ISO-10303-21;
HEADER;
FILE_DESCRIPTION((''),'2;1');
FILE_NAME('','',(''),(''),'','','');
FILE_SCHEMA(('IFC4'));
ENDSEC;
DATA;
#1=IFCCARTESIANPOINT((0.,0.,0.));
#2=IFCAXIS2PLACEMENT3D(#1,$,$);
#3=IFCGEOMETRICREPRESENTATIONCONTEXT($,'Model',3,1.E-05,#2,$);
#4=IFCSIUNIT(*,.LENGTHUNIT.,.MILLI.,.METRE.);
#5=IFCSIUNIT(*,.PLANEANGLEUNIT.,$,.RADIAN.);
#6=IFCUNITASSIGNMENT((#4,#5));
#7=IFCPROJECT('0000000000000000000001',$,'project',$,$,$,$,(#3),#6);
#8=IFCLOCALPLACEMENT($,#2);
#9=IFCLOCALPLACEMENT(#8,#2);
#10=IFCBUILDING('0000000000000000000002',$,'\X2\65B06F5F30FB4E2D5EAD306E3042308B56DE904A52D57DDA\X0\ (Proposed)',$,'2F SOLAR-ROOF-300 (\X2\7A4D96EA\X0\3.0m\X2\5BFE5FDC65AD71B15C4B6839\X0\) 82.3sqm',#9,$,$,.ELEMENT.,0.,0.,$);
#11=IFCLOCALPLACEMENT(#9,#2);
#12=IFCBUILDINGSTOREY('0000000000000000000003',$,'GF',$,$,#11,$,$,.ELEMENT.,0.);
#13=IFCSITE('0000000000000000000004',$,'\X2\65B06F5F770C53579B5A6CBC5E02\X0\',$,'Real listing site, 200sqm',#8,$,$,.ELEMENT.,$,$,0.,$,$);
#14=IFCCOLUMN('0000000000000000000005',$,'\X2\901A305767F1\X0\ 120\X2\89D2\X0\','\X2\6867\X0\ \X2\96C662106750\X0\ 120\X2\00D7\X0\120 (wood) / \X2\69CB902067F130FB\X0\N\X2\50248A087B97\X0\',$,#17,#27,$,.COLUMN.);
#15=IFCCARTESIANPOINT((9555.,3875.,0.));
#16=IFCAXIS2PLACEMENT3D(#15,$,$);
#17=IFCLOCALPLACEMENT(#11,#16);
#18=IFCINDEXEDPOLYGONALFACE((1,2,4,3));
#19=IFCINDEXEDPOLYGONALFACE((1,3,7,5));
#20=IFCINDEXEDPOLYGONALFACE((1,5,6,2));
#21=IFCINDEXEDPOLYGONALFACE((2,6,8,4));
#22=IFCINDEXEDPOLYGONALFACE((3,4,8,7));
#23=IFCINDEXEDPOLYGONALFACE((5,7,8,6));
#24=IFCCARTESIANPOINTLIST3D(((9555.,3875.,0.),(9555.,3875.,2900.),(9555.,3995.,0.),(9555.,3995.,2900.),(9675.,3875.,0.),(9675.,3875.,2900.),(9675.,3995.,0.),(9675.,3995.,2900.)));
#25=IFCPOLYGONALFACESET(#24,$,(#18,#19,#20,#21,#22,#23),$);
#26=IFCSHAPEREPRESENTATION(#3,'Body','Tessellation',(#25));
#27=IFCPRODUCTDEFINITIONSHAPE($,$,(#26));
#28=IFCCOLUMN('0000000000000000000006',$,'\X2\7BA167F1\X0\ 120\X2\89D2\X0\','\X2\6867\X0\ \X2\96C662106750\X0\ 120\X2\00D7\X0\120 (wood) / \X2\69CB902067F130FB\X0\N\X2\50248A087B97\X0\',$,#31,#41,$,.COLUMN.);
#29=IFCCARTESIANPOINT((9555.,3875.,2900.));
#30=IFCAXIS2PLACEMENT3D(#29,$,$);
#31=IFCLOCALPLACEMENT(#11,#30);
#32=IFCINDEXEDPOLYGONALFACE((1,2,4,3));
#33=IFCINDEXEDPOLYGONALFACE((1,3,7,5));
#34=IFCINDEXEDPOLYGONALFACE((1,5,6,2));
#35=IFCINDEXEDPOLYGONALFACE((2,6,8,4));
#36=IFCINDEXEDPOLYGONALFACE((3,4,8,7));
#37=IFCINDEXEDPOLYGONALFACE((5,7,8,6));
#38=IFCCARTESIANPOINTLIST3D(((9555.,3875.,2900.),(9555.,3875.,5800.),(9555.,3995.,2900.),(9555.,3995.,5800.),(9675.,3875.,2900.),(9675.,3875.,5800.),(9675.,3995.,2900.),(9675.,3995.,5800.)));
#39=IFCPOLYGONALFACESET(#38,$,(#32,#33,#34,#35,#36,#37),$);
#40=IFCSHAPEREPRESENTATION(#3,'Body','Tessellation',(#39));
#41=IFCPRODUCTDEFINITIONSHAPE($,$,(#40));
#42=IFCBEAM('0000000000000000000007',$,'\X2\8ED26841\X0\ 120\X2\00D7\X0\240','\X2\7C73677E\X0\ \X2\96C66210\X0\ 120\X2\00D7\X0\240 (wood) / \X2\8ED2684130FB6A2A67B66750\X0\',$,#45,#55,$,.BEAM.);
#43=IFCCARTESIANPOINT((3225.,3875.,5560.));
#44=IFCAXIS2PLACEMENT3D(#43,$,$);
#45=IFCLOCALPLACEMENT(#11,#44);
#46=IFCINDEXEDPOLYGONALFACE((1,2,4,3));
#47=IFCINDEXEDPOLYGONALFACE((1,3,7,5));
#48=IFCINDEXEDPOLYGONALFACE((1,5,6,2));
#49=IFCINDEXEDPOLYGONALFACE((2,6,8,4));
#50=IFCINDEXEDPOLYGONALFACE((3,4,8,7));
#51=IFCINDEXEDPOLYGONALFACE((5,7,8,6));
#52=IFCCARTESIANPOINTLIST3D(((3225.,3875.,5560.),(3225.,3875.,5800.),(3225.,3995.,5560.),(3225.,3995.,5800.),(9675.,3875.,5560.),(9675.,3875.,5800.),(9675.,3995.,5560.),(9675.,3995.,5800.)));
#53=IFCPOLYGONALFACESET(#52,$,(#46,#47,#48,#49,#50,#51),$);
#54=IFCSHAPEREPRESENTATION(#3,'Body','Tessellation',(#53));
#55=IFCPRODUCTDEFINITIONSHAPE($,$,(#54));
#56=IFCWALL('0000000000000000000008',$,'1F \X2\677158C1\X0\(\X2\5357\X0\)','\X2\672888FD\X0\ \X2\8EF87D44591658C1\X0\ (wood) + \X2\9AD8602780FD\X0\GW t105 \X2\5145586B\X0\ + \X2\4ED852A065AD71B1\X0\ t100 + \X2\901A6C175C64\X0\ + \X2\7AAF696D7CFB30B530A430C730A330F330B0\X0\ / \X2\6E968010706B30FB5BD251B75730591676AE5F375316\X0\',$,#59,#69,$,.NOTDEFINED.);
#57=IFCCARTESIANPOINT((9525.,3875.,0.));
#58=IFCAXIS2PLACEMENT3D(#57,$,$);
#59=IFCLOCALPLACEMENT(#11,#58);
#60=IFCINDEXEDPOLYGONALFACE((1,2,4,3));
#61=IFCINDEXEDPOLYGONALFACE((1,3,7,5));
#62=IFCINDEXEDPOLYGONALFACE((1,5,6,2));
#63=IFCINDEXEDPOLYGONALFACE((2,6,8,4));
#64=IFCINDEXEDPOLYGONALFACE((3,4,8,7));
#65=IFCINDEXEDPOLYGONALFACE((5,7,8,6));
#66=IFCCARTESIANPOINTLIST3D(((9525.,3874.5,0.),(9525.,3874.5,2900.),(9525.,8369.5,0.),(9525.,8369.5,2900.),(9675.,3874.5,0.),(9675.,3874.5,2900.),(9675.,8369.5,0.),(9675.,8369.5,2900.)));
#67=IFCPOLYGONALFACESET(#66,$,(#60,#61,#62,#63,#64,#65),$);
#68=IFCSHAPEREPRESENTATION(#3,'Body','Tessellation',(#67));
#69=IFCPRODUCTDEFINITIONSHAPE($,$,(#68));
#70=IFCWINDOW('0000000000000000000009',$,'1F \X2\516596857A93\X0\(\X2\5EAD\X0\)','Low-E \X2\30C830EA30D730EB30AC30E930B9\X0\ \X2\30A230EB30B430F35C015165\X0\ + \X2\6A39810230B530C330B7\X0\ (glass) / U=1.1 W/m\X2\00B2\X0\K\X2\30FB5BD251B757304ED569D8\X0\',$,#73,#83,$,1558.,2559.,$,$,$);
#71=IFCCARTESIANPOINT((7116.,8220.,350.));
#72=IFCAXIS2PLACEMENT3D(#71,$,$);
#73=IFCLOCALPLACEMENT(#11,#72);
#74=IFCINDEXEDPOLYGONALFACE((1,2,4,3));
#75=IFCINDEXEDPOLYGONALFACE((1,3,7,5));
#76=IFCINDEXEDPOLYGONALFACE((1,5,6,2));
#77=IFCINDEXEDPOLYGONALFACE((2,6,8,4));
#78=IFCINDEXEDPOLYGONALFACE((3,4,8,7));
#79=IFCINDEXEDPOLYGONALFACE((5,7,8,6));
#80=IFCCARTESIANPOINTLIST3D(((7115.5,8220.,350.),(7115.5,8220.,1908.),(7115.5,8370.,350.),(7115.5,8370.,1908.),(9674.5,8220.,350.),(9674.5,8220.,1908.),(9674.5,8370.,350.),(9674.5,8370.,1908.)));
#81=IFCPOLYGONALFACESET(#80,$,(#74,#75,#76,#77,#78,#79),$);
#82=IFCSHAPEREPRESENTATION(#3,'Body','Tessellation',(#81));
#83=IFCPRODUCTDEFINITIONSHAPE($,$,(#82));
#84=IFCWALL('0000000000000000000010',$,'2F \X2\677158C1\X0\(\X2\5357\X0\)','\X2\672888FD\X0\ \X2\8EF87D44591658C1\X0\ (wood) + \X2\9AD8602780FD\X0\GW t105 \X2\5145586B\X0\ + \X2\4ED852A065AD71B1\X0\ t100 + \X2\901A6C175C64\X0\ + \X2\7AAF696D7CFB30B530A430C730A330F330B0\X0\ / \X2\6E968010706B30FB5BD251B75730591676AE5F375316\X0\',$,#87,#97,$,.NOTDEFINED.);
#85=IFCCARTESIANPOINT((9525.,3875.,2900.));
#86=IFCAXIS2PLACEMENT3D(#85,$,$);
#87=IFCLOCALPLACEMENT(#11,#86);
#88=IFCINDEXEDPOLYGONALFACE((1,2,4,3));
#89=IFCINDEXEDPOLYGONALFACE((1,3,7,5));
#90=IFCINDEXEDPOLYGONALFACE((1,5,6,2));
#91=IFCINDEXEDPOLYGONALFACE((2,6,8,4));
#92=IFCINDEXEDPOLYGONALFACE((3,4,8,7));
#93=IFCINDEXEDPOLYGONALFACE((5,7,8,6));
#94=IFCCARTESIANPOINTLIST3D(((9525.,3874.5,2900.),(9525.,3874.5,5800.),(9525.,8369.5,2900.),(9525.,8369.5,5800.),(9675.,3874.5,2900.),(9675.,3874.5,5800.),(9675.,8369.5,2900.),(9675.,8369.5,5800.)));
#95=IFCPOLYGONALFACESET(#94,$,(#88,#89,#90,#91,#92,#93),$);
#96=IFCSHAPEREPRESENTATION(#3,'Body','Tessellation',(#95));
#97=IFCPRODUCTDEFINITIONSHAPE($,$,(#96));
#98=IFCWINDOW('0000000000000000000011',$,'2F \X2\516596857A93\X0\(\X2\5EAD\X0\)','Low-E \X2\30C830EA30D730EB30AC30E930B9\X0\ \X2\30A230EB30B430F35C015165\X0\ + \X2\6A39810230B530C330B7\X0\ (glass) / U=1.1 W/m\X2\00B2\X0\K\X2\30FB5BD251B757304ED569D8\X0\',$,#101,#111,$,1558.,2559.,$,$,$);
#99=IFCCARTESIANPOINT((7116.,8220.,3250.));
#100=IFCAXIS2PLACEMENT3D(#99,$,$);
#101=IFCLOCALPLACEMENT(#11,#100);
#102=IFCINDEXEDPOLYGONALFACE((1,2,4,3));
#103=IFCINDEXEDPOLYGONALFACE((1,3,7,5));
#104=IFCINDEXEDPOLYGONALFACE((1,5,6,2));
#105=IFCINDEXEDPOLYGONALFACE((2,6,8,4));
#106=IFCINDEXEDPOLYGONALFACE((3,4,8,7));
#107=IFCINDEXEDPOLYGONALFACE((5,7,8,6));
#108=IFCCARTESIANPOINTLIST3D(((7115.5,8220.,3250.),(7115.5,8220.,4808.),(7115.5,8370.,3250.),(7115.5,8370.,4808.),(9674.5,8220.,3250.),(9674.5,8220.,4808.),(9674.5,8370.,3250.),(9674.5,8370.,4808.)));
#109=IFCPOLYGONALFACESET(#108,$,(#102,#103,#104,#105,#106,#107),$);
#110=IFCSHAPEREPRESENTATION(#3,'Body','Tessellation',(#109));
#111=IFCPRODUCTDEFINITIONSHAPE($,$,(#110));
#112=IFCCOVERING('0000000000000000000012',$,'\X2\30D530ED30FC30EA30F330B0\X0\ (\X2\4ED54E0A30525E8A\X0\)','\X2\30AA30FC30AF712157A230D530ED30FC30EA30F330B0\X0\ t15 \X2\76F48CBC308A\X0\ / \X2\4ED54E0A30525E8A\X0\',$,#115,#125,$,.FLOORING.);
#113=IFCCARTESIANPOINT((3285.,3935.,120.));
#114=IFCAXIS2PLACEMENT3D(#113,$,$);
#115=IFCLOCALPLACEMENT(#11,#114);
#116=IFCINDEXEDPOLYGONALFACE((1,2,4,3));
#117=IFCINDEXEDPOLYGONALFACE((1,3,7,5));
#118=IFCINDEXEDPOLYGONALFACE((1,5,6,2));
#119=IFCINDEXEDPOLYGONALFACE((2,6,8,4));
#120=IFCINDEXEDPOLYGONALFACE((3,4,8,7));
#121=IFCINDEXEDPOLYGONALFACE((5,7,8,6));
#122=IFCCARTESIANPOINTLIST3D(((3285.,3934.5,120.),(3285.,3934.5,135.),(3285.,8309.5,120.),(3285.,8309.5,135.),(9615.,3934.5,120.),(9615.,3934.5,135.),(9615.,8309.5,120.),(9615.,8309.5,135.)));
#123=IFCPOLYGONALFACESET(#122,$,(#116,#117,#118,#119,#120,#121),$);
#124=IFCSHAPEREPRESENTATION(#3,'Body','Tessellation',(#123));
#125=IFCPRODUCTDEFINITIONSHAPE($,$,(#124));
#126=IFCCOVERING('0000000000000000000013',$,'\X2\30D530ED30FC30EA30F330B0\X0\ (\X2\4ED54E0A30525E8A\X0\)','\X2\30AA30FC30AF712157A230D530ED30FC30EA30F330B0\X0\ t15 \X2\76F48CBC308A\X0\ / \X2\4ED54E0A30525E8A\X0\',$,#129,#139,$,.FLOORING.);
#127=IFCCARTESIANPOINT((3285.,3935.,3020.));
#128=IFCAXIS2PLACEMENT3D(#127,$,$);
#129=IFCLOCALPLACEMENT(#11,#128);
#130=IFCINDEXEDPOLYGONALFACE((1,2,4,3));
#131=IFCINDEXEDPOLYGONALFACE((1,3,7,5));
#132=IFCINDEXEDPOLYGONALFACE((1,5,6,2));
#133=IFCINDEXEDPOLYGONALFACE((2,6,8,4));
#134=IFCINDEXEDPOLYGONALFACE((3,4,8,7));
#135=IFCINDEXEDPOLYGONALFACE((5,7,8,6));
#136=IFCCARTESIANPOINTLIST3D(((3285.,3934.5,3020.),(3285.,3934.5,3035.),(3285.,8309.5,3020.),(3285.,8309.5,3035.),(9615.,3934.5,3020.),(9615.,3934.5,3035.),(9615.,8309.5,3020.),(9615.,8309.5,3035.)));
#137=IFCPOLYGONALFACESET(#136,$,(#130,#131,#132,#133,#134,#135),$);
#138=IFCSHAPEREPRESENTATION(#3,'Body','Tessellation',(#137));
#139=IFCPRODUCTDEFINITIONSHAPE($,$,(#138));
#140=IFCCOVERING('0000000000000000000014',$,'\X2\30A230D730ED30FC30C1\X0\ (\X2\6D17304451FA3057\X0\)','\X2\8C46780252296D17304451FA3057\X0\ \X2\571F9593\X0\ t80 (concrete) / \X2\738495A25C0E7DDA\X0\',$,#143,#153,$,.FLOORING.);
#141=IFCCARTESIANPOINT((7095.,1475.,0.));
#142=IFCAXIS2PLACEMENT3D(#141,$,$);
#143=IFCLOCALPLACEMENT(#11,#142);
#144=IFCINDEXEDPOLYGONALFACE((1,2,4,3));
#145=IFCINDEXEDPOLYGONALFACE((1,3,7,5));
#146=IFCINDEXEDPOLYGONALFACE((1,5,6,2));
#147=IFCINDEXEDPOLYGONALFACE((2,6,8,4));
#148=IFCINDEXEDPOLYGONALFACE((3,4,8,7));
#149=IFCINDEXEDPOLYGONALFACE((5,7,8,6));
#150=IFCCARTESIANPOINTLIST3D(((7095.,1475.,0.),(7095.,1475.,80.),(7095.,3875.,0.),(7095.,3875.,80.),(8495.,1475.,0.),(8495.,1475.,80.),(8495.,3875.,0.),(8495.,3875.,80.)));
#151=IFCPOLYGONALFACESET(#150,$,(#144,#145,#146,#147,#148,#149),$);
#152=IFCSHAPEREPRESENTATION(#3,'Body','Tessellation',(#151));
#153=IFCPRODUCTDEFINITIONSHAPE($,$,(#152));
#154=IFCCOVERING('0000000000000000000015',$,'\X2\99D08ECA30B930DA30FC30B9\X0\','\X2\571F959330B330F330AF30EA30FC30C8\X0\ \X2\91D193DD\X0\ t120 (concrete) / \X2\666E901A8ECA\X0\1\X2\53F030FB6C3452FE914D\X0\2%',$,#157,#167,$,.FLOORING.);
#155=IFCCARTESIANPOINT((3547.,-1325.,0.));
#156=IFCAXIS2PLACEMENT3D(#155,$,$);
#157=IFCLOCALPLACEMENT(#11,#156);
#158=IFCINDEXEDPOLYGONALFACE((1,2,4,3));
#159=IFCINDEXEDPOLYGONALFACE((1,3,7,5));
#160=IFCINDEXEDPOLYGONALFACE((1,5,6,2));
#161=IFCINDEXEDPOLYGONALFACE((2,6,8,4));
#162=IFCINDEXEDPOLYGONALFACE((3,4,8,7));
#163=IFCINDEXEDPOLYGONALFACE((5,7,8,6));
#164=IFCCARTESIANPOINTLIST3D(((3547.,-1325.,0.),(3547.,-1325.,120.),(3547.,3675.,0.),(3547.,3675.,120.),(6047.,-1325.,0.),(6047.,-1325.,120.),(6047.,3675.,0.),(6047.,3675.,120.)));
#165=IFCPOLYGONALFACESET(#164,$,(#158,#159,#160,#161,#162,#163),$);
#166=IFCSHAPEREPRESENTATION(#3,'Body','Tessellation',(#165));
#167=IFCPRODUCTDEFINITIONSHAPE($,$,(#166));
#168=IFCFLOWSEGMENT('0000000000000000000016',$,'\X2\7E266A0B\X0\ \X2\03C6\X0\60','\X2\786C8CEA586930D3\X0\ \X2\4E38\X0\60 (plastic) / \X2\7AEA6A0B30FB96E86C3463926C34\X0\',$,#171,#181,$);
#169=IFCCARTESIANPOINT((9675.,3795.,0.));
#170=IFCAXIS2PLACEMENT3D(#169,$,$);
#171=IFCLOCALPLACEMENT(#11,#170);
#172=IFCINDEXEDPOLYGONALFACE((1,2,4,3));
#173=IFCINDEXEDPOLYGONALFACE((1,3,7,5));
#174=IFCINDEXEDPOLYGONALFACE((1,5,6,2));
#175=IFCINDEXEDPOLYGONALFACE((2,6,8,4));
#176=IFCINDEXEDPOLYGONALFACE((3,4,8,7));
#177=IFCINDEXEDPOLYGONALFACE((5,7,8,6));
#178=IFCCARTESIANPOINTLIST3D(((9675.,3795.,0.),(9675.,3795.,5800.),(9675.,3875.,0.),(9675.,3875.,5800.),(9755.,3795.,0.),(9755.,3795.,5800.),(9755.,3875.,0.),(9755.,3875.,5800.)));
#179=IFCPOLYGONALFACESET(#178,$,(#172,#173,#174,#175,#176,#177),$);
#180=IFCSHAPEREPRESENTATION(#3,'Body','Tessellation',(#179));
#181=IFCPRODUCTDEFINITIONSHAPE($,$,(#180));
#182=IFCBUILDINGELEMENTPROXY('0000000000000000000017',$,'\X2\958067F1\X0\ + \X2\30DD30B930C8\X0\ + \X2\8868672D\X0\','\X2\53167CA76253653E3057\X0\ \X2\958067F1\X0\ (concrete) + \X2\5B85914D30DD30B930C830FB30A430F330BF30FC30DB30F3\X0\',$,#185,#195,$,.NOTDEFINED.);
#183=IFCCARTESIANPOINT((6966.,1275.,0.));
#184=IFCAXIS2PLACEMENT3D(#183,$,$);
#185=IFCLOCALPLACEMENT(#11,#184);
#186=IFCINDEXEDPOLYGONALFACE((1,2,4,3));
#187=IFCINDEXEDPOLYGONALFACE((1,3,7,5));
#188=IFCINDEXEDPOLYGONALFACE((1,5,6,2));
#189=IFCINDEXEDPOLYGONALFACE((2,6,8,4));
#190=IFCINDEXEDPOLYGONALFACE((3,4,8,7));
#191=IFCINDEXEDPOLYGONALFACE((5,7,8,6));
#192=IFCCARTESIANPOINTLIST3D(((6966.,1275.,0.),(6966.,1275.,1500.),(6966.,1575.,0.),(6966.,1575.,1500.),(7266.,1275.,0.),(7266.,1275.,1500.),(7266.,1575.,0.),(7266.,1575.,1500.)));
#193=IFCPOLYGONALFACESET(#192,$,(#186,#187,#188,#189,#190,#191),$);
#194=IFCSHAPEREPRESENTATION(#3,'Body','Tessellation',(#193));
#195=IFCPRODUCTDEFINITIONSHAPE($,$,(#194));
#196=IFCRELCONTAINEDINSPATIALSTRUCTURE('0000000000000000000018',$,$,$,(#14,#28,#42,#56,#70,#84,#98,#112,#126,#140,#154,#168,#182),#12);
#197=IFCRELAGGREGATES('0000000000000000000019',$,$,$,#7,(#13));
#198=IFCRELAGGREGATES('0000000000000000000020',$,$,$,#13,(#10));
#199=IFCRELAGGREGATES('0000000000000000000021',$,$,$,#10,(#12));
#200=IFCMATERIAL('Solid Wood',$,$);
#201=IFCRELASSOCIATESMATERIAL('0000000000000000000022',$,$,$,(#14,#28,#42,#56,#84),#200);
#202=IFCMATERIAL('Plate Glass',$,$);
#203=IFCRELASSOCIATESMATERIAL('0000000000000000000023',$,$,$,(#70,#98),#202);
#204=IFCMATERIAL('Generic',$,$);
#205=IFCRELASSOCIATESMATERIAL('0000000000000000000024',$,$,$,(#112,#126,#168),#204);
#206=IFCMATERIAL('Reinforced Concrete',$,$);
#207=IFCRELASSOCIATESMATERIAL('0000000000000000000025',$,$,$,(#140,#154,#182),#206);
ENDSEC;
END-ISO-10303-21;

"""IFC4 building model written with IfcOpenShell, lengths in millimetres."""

from ifc_helpers import new_model, si_unit, frame, frame_2d, origin, place, context, project, spatial, rectangle, extrude, material, element, fill, save


model = new_model("IFC4")

# Units and contexts
model_context = context("Model", 3, precision=1e-05, world=origin())
ifc_project = project(units=[si_unit("LENGTHUNIT", "METRE", prefix="MILLI"), si_unit("PLANEANGLEUNIT", "RADIAN")], contexts=[model_context])

# Site, building, storey
site_placement = place(None, origin())
site = spatial("IfcSite", under=ifc_project, at=site_placement, Name="新潟県南魚沼市", ObjectType="Real listing site, 200sqm", CompositionType="ELEMENT", RefElevation=0.0)
building_placement = place(site_placement, origin())
building = spatial("IfcBuilding", under=site, at=building_placement, Name="新潟・中庭のある回遊動線 (Proposed)", ObjectType="2F SOLAR-ROOF-300 (積雪3.0m対応断熱屋根) 82.3sqm", CompositionType="ELEMENT", ElevationOfRefHeight=0.0, ElevationOfTerrain=0.0)
storey_placement = place(building_placement, origin())
storey = spatial("IfcBuildingStorey", under=building, at=storey_placement, Name="GF", CompositionType="ELEMENT", Elevation=0.0)

# Columns
ifc_material_1 = material(Name="Solid Wood")
column_1_placement = place(storey_placement, frame((9555.0, 3875.0, 0.0)))
element("IfcColumn", 1, at=column_1_placement, inside=storey, material=ifc_material_1, Name="通し柱 120角", Description="桧 集成材 120×120 (wood) / 構造柱・N値計算", PredefinedType="COLUMN", context=model_context, shape_type="SweptSolid", body=[
    extrude(rectangle(XDim=120.0, YDim=120.0, at=frame_2d((60.0, 60.0))), frame((9555.0, 3875.0, 0.0)), (0.0, 0.0, 1.0), 2900.0),
])
column_2_placement = place(storey_placement, frame((9555.0, 3875.0, 2900.0)))
element("IfcColumn", 2, at=column_2_placement, inside=storey, material=ifc_material_1, Name="管柱 120角", Description="桧 集成材 120×120 (wood) / 構造柱・N値計算", PredefinedType="COLUMN", context=model_context, shape_type="SweptSolid", body=[
    extrude(rectangle(XDim=120.0, YDim=120.0, at=frame_2d((60.0, 60.0))), frame((9555.0, 3875.0, 2900.0)), (0.0, 0.0, 1.0), 2900.0),
])

# Beam
beam_1_placement = place(storey_placement, frame((3225.0, 3875.0, 5560.0)))
element("IfcBeam", 3, at=beam_1_placement, inside=storey, material=ifc_material_1, Name="軒桁 120×240", Description="米松 集成 120×240 (wood) / 軒桁・横架材", PredefinedType="BEAM", context=model_context, shape_type="SweptSolid", body=[
    extrude(rectangle(XDim=6450.0, YDim=120.0, at=frame_2d((3225.0, 60.0))), frame((3225.0, 3875.0, 5560.0)), (0.0, 0.0, 1.0), 240.0),
])

# Wall, opening, window
wall_1_placement = place(storey_placement, frame((9525.0, 3875.0, 0.0)))
wall_1 = element("IfcWall", 4, at=wall_1_placement, inside=storey, material=ifc_material_1, Name="1F 東壁(南)", Description="木製 軸組外壁 (wood) + 高性能GW t105 充填 + 付加断熱 t100 + 通気層 + 窯業系サイディング / 準耐火・寒冷地外皮強化", PredefinedType="NOTDEFINED", context=model_context, shape_type="SweptSolid", body=[
    extrude(rectangle(XDim=150.0, YDim=4495.0, at=frame_2d((75.0, 2247.0))), frame((9525.0, 3875.0, 0.0)), (0.0, 0.0, 1.0), 2900.0),
])
opening_1_placement = place(storey_placement, frame((7116.0, 8220.0, 350.0)))
opening_1 = element("IfcOpeningElement", 5, at=opening_1_placement, cuts=wall_1, PredefinedType="NOTDEFINED", context=model_context, shape_type="SweptSolid", body=[
    extrude(rectangle(XDim=2559.0, YDim=150.0, at=frame_2d((1279.0, 75.0))), frame((7116.0, 8220.0, 350.0)), (0.0, 0.0, 1.0), 1558.0),
])
ifc_material_2 = material(Name="Plate Glass")
window_1_placement = place(storey_placement, frame((7116.0, 8220.0, 350.0)))
window_1 = element("IfcWindow", 6, at=window_1_placement, inside=storey, material=ifc_material_2, Name="1F 入隅窓(庭)", Description="Low-E トリプルガラス アルゴン封入 + 樹脂サッシ (glass) / U=1.1 W/m²K・寒冷地仕様", OverallHeight=1558.0, OverallWidth=2559.0, context=model_context, shape_type="SweptSolid", body=[
    extrude(rectangle(XDim=2559.0, YDim=150.0, at=frame_2d((1279.0, 75.0))), frame((7116.0, 8220.0, 350.0)), (0.0, 0.0, 1.0), 1558.0),
])
fill(opening_1, window_1)

# Wall, opening, window
wall_2_placement = place(storey_placement, frame((9525.0, 3875.0, 2900.0)))
wall_2 = element("IfcWall", 7, at=wall_2_placement, inside=storey, material=ifc_material_1, Name="2F 東壁(南)", Description="木製 軸組外壁 (wood) + 高性能GW t105 充填 + 付加断熱 t100 + 通気層 + 窯業系サイディング / 準耐火・寒冷地外皮強化", PredefinedType="NOTDEFINED", context=model_context, shape_type="SweptSolid", body=[
    extrude(rectangle(XDim=150.0, YDim=4495.0, at=frame_2d((75.0, 2247.0))), frame((9525.0, 3875.0, 2900.0)), (0.0, 0.0, 1.0), 2900.0),
])
opening_2_placement = place(storey_placement, frame((7116.0, 8220.0, 3250.0)))
opening_2 = element("IfcOpeningElement", 8, at=opening_2_placement, cuts=wall_2, PredefinedType="NOTDEFINED", context=model_context, shape_type="SweptSolid", body=[
    extrude(rectangle(XDim=2559.0, YDim=150.0, at=frame_2d((1279.0, 75.0))), frame((7116.0, 8220.0, 3250.0)), (0.0, 0.0, 1.0), 1558.0),
])
window_2_placement = place(storey_placement, frame((7116.0, 8220.0, 3250.0)))
window_2 = element("IfcWindow", 9, at=window_2_placement, inside=storey, material=ifc_material_2, Name="2F 入隅窓(庭)", Description="Low-E トリプルガラス アルゴン封入 + 樹脂サッシ (glass) / U=1.1 W/m²K・寒冷地仕様", OverallHeight=1558.0, OverallWidth=2559.0, context=model_context, shape_type="SweptSolid", body=[
    extrude(rectangle(XDim=2559.0, YDim=150.0, at=frame_2d((1279.0, 75.0))), frame((7116.0, 8220.0, 3250.0)), (0.0, 0.0, 1.0), 1558.0),
])
fill(opening_2, window_2)

# Coverings
ifc_material_3 = material(Name="Generic")
covering_1_placement = place(storey_placement, frame((3285.0, 3935.0, 120.0)))
element("IfcCovering", 10, at=covering_1_placement, inside=storey, material=ifc_material_3, Name="フローリング (仕上げ床)", Description="オーク無垢フローリング t15 直貼り / 仕上げ床", PredefinedType="FLOORING", context=model_context, shape_type="SweptSolid", body=[
    extrude(rectangle(XDim=6330.0, YDim=4375.0, at=frame_2d((3165.0, 2187.0))), frame((3285.0, 3935.0, 120.0)), (0.0, 0.0, 1.0), 15.0),
])
covering_2_placement = place(storey_placement, frame((3285.0, 3935.0, 3020.0)))
element("IfcCovering", 11, at=covering_2_placement, inside=storey, material=ifc_material_3, Name="フローリング (仕上げ床)", Description="オーク無垢フローリング t15 直貼り / 仕上げ床", PredefinedType="FLOORING", context=model_context, shape_type="SweptSolid", body=[
    extrude(rectangle(XDim=6330.0, YDim=4375.0, at=frame_2d((3165.0, 2187.0))), frame((3285.0, 3935.0, 3020.0)), (0.0, 0.0, 1.0), 15.0),
])
ifc_material_4 = material(Name="Reinforced Concrete")
covering_3_placement = place(storey_placement, frame((7095.0, 1475.0, 0.0)))
element("IfcCovering", 12, at=covering_3_placement, inside=storey, material=ifc_material_4, Name="アプローチ (洗い出し)", Description="豆砂利洗い出し 土間 t80 (concrete) / 玄関導線", PredefinedType="FLOORING", context=model_context, shape_type="SweptSolid", body=[
    extrude(rectangle(XDim=1400.0, YDim=2400.0, at=frame_2d((700.0, 1200.0))), frame((7095.0, 1475.0, 0.0)), (0.0, 0.0, 1.0), 80.0),
])
covering_4_placement = place(storey_placement, frame((3547.0, -1325.0, 0.0)))
element("IfcCovering", 13, at=covering_4_placement, inside=storey, material=ifc_material_4, Name="駐車スペース", Description="土間コンクリート 金鏝 t120 (concrete) / 普通車1台・水勾配2%", PredefinedType="FLOORING", context=model_context, shape_type="SweptSolid", body=[
    extrude(rectangle(XDim=2500.0, YDim=5000.0, at=frame_2d((1250.0, 2500.0))), frame((3547.0, -1325.0, 0.0)), (0.0, 0.0, 1.0), 120.0),
])

# Flow segment
flow_segment_placement = place(storey_placement, frame((9675.0, 3795.0, 0.0)))
element("IfcFlowSegment", 14, at=flow_segment_placement, inside=storey, material=ifc_material_3, Name="縦樋 φ60", Description="硬質塩ビ 丸60 (plastic) / 竪樋・雨水排水", context=model_context, shape_type="SweptSolid", body=[
    extrude(rectangle(XDim=80.0, YDim=80.0, at=frame_2d((40.0, 40.0))), frame((9675.0, 3795.0, 0.0)), (0.0, 0.0, 1.0), 5800.0),
])

# Building element proxy
proxy_placement = place(storey_placement, frame((6966.0, 1275.0, 0.0)))
element("IfcBuildingElementProxy", 15, at=proxy_placement, inside=storey, material=ifc_material_4, Name="門柱 + ポスト + 表札", Description="化粧打放し 門柱 (concrete) + 宅配ポスト・インターホン", PredefinedType="NOTDEFINED", context=model_context, shape_type="SweptSolid", body=[
    extrude(rectangle(XDim=300.0, YDim=300.0, at=frame_2d((150.0, 150.0))), frame((6966.0, 1275.0, 0.0)), (0.0, 0.0, 1.0), 1500.0),
])

save(model, "model.ifc")
